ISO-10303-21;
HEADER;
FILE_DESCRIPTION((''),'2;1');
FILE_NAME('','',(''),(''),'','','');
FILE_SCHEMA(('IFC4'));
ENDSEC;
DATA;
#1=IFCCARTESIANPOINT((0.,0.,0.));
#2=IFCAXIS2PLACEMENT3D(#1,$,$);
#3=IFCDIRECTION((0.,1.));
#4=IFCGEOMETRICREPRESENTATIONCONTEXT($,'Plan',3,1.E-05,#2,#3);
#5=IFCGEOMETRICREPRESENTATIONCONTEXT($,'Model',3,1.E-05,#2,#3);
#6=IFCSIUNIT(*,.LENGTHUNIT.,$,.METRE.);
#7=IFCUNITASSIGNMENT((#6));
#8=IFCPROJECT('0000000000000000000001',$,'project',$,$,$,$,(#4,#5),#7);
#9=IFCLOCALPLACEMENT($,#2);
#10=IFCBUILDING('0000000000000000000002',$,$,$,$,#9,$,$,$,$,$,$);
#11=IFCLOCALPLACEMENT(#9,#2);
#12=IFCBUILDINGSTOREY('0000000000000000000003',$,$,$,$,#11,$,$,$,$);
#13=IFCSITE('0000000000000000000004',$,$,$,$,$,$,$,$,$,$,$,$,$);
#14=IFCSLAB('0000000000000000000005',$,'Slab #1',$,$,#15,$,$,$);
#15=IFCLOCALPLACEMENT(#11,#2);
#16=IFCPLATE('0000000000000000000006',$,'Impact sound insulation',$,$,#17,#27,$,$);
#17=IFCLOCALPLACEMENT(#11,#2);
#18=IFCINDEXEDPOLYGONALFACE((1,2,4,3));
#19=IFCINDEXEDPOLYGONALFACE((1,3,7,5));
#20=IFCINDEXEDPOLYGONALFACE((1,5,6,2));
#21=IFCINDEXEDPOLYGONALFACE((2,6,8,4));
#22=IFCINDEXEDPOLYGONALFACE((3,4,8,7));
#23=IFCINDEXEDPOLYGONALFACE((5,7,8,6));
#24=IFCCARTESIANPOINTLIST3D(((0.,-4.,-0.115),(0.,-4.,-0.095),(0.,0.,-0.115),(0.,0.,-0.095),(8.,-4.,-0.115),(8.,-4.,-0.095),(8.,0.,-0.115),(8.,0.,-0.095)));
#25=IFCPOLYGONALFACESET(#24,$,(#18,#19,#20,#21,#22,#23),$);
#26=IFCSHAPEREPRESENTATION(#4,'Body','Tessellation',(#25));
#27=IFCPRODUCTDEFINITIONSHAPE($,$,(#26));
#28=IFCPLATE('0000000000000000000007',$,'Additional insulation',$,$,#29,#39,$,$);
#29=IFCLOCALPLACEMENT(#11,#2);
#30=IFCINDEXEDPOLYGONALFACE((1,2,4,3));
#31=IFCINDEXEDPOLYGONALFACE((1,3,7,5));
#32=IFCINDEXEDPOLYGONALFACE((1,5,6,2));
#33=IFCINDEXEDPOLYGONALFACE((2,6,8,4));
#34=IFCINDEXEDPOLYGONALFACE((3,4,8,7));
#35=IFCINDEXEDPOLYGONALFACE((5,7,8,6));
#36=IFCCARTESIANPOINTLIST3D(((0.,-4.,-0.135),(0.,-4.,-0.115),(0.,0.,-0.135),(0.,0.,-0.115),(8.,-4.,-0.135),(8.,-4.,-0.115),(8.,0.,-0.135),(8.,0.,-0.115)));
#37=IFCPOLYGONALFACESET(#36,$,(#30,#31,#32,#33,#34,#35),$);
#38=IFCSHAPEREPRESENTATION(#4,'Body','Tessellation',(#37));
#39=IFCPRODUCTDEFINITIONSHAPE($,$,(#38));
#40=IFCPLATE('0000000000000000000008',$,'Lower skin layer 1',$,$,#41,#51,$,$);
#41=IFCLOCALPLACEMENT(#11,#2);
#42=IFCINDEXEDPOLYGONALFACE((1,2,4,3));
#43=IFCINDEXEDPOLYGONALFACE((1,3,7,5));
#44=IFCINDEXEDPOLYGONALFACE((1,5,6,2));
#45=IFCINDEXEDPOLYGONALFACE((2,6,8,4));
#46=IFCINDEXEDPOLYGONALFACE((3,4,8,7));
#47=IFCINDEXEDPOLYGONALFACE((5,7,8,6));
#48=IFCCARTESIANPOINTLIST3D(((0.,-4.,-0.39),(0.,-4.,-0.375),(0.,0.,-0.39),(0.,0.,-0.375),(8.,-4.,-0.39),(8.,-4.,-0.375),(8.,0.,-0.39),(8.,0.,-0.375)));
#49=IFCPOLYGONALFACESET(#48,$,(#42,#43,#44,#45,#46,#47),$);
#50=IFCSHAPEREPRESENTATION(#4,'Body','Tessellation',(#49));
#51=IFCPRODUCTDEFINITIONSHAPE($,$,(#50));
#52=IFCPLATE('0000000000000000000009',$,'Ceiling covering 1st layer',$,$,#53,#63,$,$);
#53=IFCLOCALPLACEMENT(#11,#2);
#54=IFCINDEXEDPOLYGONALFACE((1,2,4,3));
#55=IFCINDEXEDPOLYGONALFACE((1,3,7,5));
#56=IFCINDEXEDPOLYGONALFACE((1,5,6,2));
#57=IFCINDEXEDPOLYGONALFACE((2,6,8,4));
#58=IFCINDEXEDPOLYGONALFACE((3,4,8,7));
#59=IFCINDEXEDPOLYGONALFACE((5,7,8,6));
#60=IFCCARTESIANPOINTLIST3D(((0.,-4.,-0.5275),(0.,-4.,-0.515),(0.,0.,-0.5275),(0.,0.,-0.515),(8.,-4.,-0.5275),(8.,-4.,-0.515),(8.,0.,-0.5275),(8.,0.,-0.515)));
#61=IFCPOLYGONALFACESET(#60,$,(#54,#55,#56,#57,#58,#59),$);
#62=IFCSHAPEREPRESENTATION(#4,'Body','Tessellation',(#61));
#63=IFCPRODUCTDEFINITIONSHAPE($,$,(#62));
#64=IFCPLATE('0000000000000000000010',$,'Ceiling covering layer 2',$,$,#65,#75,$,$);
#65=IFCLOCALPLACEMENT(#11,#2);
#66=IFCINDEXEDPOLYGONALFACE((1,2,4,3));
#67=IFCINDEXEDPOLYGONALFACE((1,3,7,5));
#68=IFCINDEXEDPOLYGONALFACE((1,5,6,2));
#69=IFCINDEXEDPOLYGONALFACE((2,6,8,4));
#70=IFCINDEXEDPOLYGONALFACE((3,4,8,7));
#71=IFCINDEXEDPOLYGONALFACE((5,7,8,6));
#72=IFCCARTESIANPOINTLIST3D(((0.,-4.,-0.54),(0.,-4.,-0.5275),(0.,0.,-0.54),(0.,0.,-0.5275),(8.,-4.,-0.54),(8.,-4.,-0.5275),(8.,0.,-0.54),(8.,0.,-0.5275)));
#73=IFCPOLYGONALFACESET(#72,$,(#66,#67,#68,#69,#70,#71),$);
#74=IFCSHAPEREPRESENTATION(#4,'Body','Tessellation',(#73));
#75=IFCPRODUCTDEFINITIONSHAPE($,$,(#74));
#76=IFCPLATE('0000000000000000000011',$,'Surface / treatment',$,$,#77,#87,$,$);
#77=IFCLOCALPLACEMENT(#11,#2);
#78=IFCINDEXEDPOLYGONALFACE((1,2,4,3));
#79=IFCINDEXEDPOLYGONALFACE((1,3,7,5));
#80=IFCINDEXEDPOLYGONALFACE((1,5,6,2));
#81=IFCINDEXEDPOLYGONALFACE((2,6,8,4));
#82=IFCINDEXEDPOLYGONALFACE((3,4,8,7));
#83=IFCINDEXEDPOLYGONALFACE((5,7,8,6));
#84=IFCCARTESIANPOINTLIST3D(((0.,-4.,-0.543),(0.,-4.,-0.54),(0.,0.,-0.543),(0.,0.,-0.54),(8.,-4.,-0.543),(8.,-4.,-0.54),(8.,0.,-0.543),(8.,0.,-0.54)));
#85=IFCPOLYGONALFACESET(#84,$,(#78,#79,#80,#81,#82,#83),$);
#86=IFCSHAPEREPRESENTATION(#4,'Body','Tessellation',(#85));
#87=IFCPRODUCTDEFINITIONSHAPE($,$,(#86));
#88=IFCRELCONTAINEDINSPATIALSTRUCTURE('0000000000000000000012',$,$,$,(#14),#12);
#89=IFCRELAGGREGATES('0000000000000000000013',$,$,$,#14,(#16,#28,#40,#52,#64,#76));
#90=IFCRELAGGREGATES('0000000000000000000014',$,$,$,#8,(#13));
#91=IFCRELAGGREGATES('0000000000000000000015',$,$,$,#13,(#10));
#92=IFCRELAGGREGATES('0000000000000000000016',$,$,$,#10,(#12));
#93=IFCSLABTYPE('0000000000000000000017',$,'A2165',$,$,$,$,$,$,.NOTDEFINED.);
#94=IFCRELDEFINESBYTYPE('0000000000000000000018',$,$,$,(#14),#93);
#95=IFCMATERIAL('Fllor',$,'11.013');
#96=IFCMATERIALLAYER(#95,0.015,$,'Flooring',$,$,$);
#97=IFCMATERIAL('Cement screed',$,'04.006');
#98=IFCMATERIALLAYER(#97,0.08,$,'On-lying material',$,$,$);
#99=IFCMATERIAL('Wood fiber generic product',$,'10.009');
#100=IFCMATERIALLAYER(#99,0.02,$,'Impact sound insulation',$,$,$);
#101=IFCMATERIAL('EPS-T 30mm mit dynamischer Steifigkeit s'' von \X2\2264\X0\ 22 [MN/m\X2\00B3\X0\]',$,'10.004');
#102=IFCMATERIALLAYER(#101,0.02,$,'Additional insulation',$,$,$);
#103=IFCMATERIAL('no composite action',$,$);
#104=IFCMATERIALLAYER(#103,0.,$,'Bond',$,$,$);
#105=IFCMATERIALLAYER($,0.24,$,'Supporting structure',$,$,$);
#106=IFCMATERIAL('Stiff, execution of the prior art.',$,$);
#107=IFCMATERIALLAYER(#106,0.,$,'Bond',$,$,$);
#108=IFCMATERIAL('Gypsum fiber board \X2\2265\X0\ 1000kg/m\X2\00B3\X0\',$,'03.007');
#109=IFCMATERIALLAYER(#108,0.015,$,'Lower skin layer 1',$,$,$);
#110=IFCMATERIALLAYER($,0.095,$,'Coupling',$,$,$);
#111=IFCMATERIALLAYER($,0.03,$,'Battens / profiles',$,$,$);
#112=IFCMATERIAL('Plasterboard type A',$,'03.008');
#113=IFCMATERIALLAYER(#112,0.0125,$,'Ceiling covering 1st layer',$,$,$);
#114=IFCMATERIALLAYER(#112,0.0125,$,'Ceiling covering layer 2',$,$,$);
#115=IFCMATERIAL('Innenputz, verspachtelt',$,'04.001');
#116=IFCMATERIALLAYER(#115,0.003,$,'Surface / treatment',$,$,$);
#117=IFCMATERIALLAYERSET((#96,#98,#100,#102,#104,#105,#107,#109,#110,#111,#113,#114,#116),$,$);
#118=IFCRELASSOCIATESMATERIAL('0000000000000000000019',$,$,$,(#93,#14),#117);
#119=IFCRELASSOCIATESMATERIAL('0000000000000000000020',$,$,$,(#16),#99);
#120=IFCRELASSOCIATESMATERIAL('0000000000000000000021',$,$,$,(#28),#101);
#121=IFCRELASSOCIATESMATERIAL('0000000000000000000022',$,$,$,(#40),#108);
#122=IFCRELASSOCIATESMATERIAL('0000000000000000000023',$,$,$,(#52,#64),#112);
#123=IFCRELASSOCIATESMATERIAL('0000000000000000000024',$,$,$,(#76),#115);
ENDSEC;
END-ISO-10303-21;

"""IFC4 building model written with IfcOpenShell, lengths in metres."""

from ifc_helpers import new_model, si_unit, direction, frame, frame_2d, origin, place, context, project, spatial, rectangle, extrude, material, layer, layer_set, type_object, element, aggregate, save


model = new_model("IFC4")

# Units and contexts
plan_context = context("Plan", 3, precision=1e-05, world=origin(), true_north=direction((0.0, 1.0)))
model_context = context("Model", 3, precision=1e-05, world=origin(), true_north=direction((0.0, 1.0)))
ifc_project = project(units=[si_unit("LENGTHUNIT", "METRE")], contexts=[plan_context, model_context])

# Site, building, storey
site = spatial("IfcSite", under=ifc_project)
building_placement = place(None, origin())
building = spatial("IfcBuilding", under=site, at=building_placement)
storey_placement = place(building_placement, origin())
storey = spatial("IfcBuildingStorey", under=building, at=storey_placement)

# Slab, plates
ifc_material_1 = material(Name="Fllor", Category="11.013")
ifc_layer_1 = layer(ifc_material_1, 0.015, Name="Flooring")
ifc_material_2 = material(Name="Cement screed", Category="04.006")
ifc_layer_2 = layer(ifc_material_2, 0.08, Name="On-lying material")
ifc_material_3 = material(Name="Wood fiber generic product", Category="10.009")
ifc_layer_3 = layer(ifc_material_3, 0.02, Name="Impact sound insulation")
ifc_material_4 = material(Name="EPS-T 30mm mit dynamischer Steifigkeit s' von ≤ 22 [MN/m³]", Category="10.004")
ifc_layer_4 = layer(ifc_material_4, 0.02, Name="Additional insulation")
ifc_material_5 = material(Name="no composite action")
ifc_layer_5 = layer(ifc_material_5, 0.0, Name="Bond")
ifc_layer_6 = layer(None, 0.24, Name="Supporting structure")
ifc_material_6 = material(Name="Stiff, execution of the prior art.")
ifc_layer_7 = layer(ifc_material_6, 0.0, Name="Bond")
ifc_material_7 = material(Name="Gypsum fiber board ≥ 1000kg/m³", Category="03.007")
ifc_layer_8 = layer(ifc_material_7, 0.015, Name="Lower skin layer 1")
ifc_layer_9 = layer(None, 0.095, Name="Coupling")
ifc_layer_10 = layer(None, 0.03, Name="Battens / profiles")
ifc_material_8 = material(Name="Plasterboard type A", Category="03.008")
ifc_layer_11 = layer(ifc_material_8, 0.0125, Name="Ceiling covering 1st layer")
ifc_layer_12 = layer(ifc_material_8, 0.0125, Name="Ceiling covering layer 2")
ifc_material_9 = material(Name="Innenputz, verspachtelt", Category="04.001")
ifc_layer_13 = layer(ifc_material_9, 0.003, Name="Surface / treatment")
ifc_layer_set = layer_set([ifc_layer_1, ifc_layer_2, ifc_layer_3, ifc_layer_4, ifc_layer_5, ifc_layer_6, ifc_layer_7, ifc_layer_8, ifc_layer_9, ifc_layer_10, ifc_layer_11, ifc_layer_12, ifc_layer_13])
slab_type = type_object("IfcSlabType", Name="A2165", PredefinedType="NOTDEFINED", material=ifc_layer_set)
slab_placement = place(None, frame((0.0, 0.0, 0.0), z_axis=(0.0, 0.0, -1.0), x_axis=(1.0, 0.0, 0.0)))
slab = element("IfcSlab", 1, at=slab_placement, inside=storey, type_object=slab_type, material=ifc_layer_set, Name="Slab #1")
plate_1_placement = place(slab_placement, origin())
plate_1 = element("IfcPlate", 2, at=plate_1_placement, material=ifc_material_3, Name="Impact sound insulation", context=plan_context, shape_type="SweptSolid", body=[
    extrude(rectangle(XDim=8.0, YDim=4.0, at=frame_2d((4.0, 2.0), x_axis=(1.0, 0.0))), frame((0.0, 0.0, 0.095), z_axis=(0.0, 0.0, 1.0), x_axis=(1.0, 0.0, 0.0)), (0.0, 0.0, 1.0), 0.02),
])
plate_2_placement = place(slab_placement, origin())
plate_2 = element("IfcPlate", 3, at=plate_2_placement, material=ifc_material_4, Name="Additional insulation", context=plan_context, shape_type="SweptSolid", body=[
    extrude(rectangle(XDim=8.0, YDim=4.0, at=frame_2d((4.0, 2.0), x_axis=(1.0, 0.0))), frame((0.0, 0.0, 0.115), z_axis=(0.0, 0.0, 1.0), x_axis=(1.0, 0.0, 0.0)), (0.0, 0.0, 1.0), 0.02),
])
plate_3_placement = place(slab_placement, origin())
plate_3 = element("IfcPlate", 4, at=plate_3_placement, material=ifc_material_7, Name="Lower skin layer 1", context=plan_context, shape_type="SweptSolid", body=[
    extrude(rectangle(XDim=8.0, YDim=4.0, at=frame_2d((4.0, 2.0), x_axis=(1.0, 0.0))), frame((0.0, 0.0, 0.375), z_axis=(0.0, 0.0, 1.0), x_axis=(1.0, 0.0, 0.0)), (0.0, 0.0, 1.0), 0.015),
])
plate_4_placement = place(slab_placement, origin())
plate_4 = element("IfcPlate", 5, at=plate_4_placement, material=ifc_material_8, Name="Ceiling covering 1st layer", context=plan_context, shape_type="SweptSolid", body=[
    extrude(rectangle(XDim=8.0, YDim=4.0, at=frame_2d((4.0, 2.0), x_axis=(1.0, 0.0))), frame((0.0, 0.0, 0.515), z_axis=(0.0, 0.0, 1.0), x_axis=(1.0, 0.0, 0.0)), (0.0, 0.0, 1.0), 0.0125),
])
plate_5_placement = place(slab_placement, origin())
plate_5 = element("IfcPlate", 6, at=plate_5_placement, material=ifc_material_8, Name="Ceiling covering layer 2", context=plan_context, shape_type="SweptSolid", body=[
    extrude(rectangle(XDim=8.0, YDim=4.0, at=frame_2d((4.0, 2.0), x_axis=(1.0, 0.0))), frame((0.0, 0.0, 0.5275), z_axis=(0.0, 0.0, 1.0), x_axis=(1.0, 0.0, 0.0)), (0.0, 0.0, 1.0), 0.0125),
])
plate_6_placement = place(slab_placement, origin())
plate_6 = element("IfcPlate", 7, at=plate_6_placement, material=ifc_material_9, Name="Surface / treatment", context=plan_context, shape_type="SweptSolid", body=[
    extrude(rectangle(XDim=8.0, YDim=4.0, at=frame_2d((4.0, 2.0), x_axis=(1.0, 0.0))), frame((0.0, 0.0, 0.54), z_axis=(0.0, 0.0, 1.0), x_axis=(1.0, 0.0, 0.0)), (0.0, 0.0, 1.0), 0.003),
])
aggregate(slab, [plate_1, plate_2, plate_3, plate_4, plate_5, plate_6])

save(model, "model.ifc")
